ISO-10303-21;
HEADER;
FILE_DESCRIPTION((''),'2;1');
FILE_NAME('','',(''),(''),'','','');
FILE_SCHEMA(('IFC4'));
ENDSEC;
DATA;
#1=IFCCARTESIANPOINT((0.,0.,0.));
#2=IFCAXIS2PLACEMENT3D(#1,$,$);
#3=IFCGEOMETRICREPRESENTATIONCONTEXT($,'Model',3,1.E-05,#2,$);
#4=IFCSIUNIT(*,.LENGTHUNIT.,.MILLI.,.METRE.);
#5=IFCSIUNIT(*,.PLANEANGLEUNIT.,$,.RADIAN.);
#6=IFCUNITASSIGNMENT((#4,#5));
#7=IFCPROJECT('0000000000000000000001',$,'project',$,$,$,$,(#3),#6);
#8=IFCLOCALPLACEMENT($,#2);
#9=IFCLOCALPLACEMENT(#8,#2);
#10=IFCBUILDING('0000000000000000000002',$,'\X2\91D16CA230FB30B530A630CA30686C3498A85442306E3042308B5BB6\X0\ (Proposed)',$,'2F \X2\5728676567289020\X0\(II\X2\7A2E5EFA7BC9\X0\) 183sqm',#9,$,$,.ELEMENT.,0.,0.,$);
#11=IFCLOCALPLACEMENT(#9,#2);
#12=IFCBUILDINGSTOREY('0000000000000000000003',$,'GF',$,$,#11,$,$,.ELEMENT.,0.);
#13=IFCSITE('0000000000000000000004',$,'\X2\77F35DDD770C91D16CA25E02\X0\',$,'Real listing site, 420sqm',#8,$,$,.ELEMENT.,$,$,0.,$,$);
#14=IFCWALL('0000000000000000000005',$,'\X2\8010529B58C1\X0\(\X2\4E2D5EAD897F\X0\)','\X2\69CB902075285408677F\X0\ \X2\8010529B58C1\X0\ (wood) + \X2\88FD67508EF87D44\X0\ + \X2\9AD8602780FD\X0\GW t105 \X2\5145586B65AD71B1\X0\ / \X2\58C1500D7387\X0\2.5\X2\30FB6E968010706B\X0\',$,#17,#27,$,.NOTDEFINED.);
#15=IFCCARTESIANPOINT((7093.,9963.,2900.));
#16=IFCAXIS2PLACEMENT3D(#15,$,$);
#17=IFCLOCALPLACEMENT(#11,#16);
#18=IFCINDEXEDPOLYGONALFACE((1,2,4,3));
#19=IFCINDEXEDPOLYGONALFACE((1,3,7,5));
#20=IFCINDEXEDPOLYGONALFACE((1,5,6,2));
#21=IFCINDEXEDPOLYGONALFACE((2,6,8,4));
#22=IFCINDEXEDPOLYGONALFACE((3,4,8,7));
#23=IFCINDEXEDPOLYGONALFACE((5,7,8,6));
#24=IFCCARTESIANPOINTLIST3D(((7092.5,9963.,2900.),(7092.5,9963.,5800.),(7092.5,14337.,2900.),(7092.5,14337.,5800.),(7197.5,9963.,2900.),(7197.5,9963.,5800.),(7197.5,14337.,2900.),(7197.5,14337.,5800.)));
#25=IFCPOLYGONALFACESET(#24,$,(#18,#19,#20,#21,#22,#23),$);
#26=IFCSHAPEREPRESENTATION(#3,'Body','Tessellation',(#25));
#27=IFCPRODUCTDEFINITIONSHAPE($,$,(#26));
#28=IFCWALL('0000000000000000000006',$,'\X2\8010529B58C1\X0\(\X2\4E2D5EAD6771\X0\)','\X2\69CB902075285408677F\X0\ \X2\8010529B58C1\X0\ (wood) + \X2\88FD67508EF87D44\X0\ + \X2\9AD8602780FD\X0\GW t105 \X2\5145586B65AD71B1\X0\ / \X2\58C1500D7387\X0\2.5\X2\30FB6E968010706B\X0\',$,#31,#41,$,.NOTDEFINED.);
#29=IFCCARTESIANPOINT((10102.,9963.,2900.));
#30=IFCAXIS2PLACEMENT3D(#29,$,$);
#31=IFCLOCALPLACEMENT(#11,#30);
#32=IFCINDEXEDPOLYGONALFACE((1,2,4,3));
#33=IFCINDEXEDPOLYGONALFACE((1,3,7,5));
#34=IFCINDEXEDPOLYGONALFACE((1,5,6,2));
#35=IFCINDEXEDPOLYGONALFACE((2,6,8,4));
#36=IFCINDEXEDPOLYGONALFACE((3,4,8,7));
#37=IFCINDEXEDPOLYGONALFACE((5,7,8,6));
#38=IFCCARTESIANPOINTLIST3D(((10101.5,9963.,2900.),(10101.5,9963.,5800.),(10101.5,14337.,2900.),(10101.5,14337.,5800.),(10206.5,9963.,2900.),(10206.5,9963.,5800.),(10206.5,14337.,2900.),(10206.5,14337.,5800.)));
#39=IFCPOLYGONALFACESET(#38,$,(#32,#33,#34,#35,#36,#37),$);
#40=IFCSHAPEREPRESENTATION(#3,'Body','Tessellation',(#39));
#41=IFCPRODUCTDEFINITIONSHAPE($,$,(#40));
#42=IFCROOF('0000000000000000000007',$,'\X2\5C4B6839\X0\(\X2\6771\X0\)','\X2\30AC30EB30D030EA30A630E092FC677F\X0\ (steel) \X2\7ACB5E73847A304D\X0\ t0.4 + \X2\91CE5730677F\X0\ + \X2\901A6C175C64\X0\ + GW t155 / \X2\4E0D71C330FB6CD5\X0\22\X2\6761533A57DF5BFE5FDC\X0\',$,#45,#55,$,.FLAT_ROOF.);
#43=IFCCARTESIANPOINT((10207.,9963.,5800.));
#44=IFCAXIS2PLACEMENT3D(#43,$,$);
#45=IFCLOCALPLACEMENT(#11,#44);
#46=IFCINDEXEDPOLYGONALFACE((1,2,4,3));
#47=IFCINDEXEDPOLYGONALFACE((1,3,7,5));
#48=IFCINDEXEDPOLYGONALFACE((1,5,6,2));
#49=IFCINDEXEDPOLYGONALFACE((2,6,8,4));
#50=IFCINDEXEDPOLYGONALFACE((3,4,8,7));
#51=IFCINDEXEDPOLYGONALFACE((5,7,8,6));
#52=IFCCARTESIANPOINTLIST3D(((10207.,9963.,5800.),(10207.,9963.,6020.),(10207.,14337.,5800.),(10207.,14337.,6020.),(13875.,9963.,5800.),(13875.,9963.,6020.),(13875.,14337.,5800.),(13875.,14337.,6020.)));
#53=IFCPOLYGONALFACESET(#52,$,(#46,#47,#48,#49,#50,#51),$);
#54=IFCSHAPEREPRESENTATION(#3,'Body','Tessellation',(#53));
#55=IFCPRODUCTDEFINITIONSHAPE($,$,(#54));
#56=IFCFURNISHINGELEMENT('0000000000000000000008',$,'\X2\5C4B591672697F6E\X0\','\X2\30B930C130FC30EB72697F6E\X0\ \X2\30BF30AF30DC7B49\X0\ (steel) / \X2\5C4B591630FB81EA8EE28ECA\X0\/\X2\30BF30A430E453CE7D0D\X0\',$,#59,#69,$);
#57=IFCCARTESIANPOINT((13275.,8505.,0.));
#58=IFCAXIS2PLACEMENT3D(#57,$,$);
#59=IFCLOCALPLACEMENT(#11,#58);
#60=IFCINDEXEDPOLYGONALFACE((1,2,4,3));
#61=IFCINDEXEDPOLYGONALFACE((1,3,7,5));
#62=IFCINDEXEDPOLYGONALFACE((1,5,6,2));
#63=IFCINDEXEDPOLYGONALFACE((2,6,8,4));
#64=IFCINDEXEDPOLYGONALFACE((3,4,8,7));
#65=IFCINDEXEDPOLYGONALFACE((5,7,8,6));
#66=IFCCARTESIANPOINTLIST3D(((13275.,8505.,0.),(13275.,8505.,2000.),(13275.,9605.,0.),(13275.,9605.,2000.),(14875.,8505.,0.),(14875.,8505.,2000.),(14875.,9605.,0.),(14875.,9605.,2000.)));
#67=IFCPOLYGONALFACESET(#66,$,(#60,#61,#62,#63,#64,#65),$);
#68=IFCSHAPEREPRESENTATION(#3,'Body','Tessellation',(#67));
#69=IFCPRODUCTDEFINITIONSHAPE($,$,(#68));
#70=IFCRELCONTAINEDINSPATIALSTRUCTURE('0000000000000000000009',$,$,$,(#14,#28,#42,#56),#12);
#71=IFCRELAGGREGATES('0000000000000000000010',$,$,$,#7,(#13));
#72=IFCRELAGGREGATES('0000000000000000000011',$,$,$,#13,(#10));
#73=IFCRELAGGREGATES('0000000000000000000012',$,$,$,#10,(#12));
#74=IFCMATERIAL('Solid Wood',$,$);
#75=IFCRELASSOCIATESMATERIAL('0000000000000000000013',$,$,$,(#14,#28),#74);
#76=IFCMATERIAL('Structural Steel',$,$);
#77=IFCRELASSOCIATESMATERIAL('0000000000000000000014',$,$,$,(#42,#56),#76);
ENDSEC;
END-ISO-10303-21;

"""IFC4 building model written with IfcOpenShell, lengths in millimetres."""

from ifc_helpers import new_model, si_unit, frame, frame_2d, origin, place, context, project, spatial, rectangle, extrude, material, element, save


model = new_model("IFC4")

# Units and contexts
model_context = context("Model", 3, precision=1e-05, world=origin())
ifc_project = project(units=[si_unit("LENGTHUNIT", "METRE", prefix="MILLI"), si_unit("PLANEANGLEUNIT", "RADIAN")], contexts=[model_context])

# Site, building, storey
site_placement = place(None, origin())
site = spatial("IfcSite", under=ifc_project, at=site_placement, Name="石川県金沢市", ObjectType="Real listing site, 420sqm", CompositionType="ELEMENT", RefElevation=0.0)
building_placement = place(site_placement, origin())
building = spatial("IfcBuilding", under=site, at=building_placement, Name="金沢・サウナと水風呂のある家 (Proposed)", ObjectType="2F 在来木造(II種建築) 183sqm", CompositionType="ELEMENT", ElevationOfRefHeight=0.0, ElevationOfTerrain=0.0)
storey_placement = place(building_placement, origin())
storey = spatial("IfcBuildingStorey", under=building, at=storey_placement, Name="GF", CompositionType="ELEMENT", Elevation=0.0)

# Shared definitions
ifc_material_1 = material(Name="Solid Wood")

# Walls
wall_1_placement = place(storey_placement, frame((7093.0, 9963.0, 2900.0)))
element("IfcWall", 1, at=wall_1_placement, inside=storey, material=ifc_material_1, Name="耐力壁(中庭西)", Description="構造用合板 耐力壁 (wood) + 製材軸組 + 高性能GW t105 充填断熱 / 壁倍率2.5・準耐火", PredefinedType="NOTDEFINED", context=model_context, shape_type="SweptSolid", body=[
    extrude(rectangle(XDim=105.0, YDim=4374.0, at=frame_2d((52.0, 2187.0))), frame((7093.0, 9963.0, 2900.0)), (0.0, 0.0, 1.0), 2900.0),
])
wall_2_placement = place(storey_placement, frame((10102.0, 9963.0, 2900.0)))
element("IfcWall", 2, at=wall_2_placement, inside=storey, material=ifc_material_1, Name="耐力壁(中庭東)", Description="構造用合板 耐力壁 (wood) + 製材軸組 + 高性能GW t105 充填断熱 / 壁倍率2.5・準耐火", PredefinedType="NOTDEFINED", context=model_context, shape_type="SweptSolid", body=[
    extrude(rectangle(XDim=105.0, YDim=4374.0, at=frame_2d((52.0, 2187.0))), frame((10102.0, 9963.0, 2900.0)), (0.0, 0.0, 1.0), 2900.0),
])

# Roof
ifc_material_2 = material(Name="Structural Steel")
for number, where, name in (
    (3, (10207.0, 9963.0, 5800.0), "屋根(東)"),
):
    element("IfcRoof", number, at=place(storey_placement, frame(where)), inside=storey, material=ifc_material_2, Name=name, Description="ガルバリウム鋼板 (steel) 立平葺き t0.4 + 野地板 + 通気層 + GW t155 / 不燃・法22条区域対応", PredefinedType="FLAT_ROOF", context=model_context, shape_type="SweptSolid", body=[
        extrude(rectangle(XDim=3668.0, YDim=4374.0, at=frame_2d((1834.0, 2187.0))), frame((10207.0, 9963.0, 5800.0)), (0.0, 0.0, 1.0), 220.0),
    ])

# Furnishing element
furnishing_placement = place(storey_placement, frame((13275.0, 8505.0, 0.0)))
element("IfcFurnishingElement", 4, at=furnishing_placement, inside=storey, material=ifc_material_2, Name="屋外物置", Description="スチール物置 タクボ等 (steel) / 屋外・自転車/タイヤ収納", context=model_context, shape_type="SweptSolid", body=[
    extrude(rectangle(XDim=1600.0, YDim=1100.0, at=frame_2d((800.0, 550.0))), frame((13275.0, 8505.0, 0.0)), (0.0, 0.0, 1.0), 2000.0),
])

save(model, "model.ifc")
